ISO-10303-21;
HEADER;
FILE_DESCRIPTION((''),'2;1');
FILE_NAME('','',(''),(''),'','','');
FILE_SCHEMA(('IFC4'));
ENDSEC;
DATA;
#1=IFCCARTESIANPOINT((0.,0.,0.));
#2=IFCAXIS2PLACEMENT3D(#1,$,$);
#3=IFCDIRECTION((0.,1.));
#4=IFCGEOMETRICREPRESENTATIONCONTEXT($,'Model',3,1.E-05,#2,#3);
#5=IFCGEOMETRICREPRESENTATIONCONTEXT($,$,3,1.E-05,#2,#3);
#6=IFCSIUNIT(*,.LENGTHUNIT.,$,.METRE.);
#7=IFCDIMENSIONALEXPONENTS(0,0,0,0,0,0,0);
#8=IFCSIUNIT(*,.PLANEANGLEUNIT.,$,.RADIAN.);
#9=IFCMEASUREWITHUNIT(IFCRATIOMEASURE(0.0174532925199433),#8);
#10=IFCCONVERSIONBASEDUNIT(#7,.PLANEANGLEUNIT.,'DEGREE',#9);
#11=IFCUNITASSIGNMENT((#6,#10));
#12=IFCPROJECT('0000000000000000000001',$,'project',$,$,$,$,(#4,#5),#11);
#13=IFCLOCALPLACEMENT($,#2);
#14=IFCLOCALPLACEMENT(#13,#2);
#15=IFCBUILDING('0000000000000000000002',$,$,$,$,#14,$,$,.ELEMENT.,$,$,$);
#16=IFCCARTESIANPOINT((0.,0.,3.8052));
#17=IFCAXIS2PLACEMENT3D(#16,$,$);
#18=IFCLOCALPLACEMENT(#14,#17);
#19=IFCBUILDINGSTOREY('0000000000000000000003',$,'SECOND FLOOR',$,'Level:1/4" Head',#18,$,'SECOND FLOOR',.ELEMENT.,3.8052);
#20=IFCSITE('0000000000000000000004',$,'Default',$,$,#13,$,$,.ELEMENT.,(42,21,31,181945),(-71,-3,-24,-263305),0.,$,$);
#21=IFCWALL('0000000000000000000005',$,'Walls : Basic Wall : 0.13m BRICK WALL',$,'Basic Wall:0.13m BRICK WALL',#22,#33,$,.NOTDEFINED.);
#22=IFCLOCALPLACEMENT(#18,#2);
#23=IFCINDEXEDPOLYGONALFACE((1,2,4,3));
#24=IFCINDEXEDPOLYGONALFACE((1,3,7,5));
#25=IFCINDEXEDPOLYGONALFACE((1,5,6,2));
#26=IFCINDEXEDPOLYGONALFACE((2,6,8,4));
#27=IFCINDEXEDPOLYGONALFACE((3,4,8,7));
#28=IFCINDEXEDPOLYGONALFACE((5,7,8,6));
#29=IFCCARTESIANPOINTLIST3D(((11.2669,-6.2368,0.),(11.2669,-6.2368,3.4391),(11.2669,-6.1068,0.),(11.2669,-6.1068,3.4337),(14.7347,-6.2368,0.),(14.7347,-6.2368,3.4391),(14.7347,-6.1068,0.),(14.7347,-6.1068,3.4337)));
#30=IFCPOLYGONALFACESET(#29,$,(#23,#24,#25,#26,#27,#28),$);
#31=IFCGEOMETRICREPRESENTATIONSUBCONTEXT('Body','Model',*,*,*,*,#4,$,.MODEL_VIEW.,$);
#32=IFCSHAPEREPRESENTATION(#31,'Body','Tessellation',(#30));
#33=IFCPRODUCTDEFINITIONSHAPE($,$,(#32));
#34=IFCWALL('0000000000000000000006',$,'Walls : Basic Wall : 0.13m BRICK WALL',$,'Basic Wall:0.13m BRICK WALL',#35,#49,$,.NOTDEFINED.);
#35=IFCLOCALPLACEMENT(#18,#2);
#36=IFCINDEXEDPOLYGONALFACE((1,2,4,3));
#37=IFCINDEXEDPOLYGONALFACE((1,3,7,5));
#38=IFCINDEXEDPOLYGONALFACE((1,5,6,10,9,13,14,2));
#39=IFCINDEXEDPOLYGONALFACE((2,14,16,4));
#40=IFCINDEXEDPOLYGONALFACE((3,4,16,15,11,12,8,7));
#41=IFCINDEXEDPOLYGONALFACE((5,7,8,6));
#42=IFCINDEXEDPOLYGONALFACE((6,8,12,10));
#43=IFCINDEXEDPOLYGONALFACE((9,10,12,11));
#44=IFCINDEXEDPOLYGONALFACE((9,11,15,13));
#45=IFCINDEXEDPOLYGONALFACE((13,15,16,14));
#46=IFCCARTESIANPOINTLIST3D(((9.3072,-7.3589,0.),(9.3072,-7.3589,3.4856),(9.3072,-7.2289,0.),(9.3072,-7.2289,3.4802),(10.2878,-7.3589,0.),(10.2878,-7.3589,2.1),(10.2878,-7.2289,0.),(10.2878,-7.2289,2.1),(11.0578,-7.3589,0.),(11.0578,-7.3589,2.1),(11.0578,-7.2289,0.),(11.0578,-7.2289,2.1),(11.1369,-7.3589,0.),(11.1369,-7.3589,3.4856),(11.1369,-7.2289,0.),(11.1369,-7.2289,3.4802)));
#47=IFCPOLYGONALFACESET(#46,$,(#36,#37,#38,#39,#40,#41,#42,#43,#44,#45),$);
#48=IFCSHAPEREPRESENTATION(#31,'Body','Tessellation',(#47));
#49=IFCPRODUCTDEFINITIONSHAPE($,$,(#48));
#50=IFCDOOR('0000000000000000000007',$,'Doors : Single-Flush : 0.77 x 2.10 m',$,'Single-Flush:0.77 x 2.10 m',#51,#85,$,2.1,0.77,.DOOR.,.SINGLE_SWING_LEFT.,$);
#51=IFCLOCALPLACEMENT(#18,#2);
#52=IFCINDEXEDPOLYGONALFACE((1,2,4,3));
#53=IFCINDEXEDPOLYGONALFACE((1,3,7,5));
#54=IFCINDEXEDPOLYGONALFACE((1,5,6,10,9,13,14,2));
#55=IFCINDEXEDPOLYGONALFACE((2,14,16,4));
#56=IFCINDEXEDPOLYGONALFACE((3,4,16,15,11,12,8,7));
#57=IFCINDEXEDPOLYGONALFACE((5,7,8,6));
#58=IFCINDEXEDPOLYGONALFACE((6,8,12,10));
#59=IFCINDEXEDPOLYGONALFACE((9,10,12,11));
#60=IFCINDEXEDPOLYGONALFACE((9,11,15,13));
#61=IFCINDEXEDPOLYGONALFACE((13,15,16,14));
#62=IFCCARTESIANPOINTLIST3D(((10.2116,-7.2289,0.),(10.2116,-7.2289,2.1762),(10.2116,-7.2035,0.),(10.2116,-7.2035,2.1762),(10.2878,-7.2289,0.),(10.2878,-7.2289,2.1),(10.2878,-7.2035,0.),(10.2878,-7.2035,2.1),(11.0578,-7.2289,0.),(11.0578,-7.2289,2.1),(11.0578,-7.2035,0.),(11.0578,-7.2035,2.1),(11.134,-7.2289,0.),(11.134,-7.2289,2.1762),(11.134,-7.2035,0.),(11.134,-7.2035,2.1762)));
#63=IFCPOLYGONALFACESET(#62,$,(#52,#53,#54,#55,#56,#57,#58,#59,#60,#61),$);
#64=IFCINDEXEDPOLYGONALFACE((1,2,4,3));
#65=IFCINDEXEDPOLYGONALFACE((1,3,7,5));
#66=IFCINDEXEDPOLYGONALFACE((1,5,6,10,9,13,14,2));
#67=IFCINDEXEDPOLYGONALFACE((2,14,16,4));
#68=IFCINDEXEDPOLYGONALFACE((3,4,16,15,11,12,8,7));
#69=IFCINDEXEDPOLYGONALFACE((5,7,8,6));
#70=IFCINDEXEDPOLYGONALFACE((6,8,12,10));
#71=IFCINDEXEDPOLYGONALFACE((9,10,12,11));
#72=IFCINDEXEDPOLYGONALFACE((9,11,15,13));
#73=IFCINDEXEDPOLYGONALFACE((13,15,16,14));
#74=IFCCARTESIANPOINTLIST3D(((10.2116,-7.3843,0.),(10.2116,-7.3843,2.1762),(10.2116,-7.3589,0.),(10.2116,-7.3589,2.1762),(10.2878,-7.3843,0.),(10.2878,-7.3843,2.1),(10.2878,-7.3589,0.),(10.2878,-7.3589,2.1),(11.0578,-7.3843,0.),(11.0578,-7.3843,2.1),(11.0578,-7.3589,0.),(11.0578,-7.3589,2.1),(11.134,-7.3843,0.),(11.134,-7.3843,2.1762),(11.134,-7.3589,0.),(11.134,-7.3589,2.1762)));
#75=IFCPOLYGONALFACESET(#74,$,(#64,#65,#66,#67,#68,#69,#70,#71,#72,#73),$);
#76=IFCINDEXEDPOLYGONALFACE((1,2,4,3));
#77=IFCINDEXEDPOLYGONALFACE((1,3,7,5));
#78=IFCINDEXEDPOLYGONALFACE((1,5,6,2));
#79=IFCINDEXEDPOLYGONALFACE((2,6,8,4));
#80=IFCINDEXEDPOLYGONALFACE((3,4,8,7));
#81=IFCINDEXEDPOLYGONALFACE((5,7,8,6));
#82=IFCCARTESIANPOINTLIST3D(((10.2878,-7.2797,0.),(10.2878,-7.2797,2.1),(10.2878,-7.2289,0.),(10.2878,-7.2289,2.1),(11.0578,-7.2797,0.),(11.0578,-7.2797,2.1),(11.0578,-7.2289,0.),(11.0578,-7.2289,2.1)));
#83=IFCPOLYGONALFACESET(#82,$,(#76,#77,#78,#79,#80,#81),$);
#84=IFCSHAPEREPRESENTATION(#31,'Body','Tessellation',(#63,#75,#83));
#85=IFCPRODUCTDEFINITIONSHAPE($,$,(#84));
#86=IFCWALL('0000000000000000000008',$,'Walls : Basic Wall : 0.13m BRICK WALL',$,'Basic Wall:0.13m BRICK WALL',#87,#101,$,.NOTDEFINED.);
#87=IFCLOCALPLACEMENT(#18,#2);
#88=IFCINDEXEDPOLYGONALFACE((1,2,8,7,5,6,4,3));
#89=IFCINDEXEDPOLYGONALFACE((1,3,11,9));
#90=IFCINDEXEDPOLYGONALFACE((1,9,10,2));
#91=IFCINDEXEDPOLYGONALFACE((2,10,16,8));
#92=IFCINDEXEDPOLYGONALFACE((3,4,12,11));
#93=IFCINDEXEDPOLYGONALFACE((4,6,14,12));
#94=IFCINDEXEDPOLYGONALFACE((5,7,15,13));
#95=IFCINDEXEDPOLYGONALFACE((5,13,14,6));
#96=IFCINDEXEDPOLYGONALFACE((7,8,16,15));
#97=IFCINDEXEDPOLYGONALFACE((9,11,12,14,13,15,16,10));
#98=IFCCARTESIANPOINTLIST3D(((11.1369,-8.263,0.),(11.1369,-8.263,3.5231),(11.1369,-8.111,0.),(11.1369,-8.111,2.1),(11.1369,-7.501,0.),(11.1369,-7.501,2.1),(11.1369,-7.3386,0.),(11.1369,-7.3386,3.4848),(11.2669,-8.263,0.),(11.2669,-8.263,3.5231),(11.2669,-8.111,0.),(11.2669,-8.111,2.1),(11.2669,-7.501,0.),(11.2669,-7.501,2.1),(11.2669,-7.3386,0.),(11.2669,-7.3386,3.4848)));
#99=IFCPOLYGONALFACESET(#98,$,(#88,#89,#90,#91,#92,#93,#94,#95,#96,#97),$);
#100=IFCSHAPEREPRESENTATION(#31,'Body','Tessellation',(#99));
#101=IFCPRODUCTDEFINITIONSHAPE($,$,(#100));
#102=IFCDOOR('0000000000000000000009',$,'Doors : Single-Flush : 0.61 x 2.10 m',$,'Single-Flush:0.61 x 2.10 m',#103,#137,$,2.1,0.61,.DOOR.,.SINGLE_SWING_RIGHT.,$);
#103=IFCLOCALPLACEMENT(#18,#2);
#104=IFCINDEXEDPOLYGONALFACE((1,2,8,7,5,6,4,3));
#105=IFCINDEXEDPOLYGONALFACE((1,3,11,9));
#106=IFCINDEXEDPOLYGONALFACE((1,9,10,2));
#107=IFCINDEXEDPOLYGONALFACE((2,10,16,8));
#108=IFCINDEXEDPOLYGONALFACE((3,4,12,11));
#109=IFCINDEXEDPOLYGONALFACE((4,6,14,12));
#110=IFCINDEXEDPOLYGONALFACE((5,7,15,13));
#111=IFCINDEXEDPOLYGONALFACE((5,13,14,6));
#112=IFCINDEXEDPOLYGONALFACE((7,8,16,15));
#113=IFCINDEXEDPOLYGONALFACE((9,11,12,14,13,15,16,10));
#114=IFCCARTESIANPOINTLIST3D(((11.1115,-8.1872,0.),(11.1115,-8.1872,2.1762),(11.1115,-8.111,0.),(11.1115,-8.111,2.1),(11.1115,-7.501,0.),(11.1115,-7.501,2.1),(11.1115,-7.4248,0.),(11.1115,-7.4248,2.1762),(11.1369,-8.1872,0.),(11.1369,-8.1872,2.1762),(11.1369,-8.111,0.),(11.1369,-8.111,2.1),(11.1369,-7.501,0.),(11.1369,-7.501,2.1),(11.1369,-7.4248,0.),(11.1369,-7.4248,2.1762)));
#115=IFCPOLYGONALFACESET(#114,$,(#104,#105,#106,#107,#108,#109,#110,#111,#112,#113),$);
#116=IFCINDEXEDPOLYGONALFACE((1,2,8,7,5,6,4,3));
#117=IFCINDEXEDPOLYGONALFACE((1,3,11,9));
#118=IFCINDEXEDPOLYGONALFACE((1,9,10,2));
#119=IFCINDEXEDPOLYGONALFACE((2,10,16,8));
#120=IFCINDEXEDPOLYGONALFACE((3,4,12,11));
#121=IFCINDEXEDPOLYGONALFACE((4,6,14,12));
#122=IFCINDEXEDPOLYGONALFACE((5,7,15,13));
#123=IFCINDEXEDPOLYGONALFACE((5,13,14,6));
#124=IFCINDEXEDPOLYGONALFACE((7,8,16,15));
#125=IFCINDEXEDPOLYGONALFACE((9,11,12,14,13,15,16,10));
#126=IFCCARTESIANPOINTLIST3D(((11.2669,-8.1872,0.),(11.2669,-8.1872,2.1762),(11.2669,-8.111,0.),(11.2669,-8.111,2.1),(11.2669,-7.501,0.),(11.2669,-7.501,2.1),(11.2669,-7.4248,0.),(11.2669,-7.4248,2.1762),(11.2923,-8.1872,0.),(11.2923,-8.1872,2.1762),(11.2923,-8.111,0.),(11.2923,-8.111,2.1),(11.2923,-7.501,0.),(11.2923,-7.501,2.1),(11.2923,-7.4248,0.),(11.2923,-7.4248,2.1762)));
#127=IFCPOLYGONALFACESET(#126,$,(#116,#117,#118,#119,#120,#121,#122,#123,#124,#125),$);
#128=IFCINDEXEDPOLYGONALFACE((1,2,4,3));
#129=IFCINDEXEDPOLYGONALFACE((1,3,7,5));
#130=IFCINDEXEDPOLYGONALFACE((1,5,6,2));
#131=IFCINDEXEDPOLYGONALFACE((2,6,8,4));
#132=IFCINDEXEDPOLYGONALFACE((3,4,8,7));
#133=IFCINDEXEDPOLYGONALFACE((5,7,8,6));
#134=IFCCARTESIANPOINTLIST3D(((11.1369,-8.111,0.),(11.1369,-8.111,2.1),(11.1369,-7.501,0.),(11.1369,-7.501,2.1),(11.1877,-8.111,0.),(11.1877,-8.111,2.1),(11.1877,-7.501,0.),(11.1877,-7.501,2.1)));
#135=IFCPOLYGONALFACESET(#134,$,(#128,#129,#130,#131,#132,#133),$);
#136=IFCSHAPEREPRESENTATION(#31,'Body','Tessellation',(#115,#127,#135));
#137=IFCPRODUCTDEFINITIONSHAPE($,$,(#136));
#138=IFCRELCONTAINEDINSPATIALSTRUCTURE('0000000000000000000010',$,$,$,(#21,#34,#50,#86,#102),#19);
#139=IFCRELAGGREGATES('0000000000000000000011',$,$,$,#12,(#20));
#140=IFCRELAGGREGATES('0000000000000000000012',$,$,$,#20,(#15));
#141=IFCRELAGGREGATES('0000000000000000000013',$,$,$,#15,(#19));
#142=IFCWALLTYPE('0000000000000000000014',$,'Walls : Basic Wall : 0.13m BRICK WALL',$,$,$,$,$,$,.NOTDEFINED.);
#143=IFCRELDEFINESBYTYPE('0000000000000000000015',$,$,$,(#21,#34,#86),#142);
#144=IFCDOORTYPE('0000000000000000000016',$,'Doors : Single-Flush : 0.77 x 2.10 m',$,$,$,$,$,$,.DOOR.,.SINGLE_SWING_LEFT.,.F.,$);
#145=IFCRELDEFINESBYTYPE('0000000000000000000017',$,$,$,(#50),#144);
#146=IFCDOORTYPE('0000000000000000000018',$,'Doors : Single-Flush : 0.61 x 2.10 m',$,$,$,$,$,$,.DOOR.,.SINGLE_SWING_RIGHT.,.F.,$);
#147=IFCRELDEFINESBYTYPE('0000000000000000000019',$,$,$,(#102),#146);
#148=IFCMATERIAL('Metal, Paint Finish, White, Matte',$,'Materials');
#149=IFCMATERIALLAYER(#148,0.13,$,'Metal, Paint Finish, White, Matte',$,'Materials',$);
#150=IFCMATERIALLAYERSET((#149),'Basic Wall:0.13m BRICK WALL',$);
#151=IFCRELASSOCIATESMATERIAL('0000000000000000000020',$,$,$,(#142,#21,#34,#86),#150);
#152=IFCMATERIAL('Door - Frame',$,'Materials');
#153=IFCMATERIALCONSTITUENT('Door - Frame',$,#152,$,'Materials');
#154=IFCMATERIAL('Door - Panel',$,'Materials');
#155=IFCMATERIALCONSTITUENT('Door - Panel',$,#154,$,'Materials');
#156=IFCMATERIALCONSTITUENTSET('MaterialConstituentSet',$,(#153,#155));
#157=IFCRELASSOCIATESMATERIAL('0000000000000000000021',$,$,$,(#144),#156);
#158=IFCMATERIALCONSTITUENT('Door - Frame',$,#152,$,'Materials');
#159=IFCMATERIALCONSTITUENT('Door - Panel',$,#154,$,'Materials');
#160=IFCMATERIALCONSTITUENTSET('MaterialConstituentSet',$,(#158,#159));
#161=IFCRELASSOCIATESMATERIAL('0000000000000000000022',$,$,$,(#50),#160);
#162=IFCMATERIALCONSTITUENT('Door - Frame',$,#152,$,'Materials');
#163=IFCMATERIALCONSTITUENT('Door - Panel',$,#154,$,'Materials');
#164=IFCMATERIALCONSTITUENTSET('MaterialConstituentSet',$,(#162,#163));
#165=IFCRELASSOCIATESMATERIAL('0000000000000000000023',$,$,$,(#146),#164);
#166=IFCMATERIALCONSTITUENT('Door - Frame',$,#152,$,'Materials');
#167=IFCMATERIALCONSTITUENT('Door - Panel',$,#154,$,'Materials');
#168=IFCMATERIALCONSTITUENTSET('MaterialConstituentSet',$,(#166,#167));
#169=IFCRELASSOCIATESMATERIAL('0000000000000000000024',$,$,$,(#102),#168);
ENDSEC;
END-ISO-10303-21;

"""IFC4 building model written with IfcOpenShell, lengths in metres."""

from ifc_helpers import new_model, entity, si_unit, converted_unit, direction, frame, frame_2d, origin, place, context, subcontext, project, spatial, polyline, rectangle, outline, extrude, clip, bounded_halfspace, source, transform, mapped, material, layer, layer_set, layer_usage, constituent, constituent_set, type_object, type_shapes, element, fill, save


model = new_model("IFC4")

# Units and contexts
model_context = context("Model", 3, precision=1e-05, world=origin(), true_north=direction((0.0, 1.0)))
context_of_model = context(None, 3, precision=1e-05, world=origin(), true_north=direction((0.0, 1.0)))
body_context = subcontext(model_context, "Body", "Model", "MODEL_VIEW")
ifc_project = project(units=[si_unit("LENGTHUNIT", "METRE"), converted_unit("PLANEANGLEUNIT", "DEGREE", entity("IfcRatioMeasure", 0.0174532925199433), si_unit("PLANEANGLEUNIT", "RADIAN"), dimensions=[0, 0, 0, 0, 0, 0, 0])], contexts=[model_context, context_of_model])

# Site, building, storey
site_placement = place(None, origin())
site = spatial("IfcSite", under=ifc_project, at=site_placement, Name="Default", CompositionType="ELEMENT", RefLatitude=(42, 21, 31, 181945), RefLongitude=(-71, -3, -24, -263305), RefElevation=0.0)
building_placement = place(site_placement, origin())
building = spatial("IfcBuilding", under=site, at=building_placement, CompositionType="ELEMENT")
storey_placement = place(building_placement, frame((0.0, 0.0, 3.8052)))
storey = spatial("IfcBuildingStorey", under=building, at=storey_placement, Name="SECOND FLOOR", ObjectType="Level:1/4\" Head", LongName="SECOND FLOOR", CompositionType="ELEMENT", Elevation=3.8052)

# Wall
ifc_material_1 = material(Name="Metal, Paint Finish, White, Matte", Category="Materials")
ifc_layer_1 = layer(ifc_material_1, 0.13, Name="Metal, Paint Finish, White, Matte", Category="Materials")
ifc_layer_set_1 = layer_set([ifc_layer_1], Name="Basic Wall:0.13m BRICK WALL")
ifc_layer_usage_1 = layer_usage(ifc_layer_set_1, "AXIS2", "NEGATIVE", 0.065)
wall_type_1 = type_object("IfcWallType", Name="Walls : Basic Wall : 0.13m BRICK WALL", PredefinedType="NOTDEFINED", material=ifc_layer_set_1)
wall_1_placement = place(storey_placement, frame((14.7347, -6.1718, 0.0), z_axis=(0.0, 0.0, 1.0), x_axis=(-1.0, 0.0, 0.0)))
element("IfcWall", 1, at=wall_1_placement, inside=storey, type_object=wall_type_1, material=ifc_layer_usage_1, Name="Walls : Basic Wall : 0.13m BRICK WALL", ObjectType="Basic Wall:0.13m BRICK WALL", PredefinedType="NOTDEFINED", context=body_context, shape_type="Clipping", body=[
    clip(extrude(rectangle(XDim=3.4678, YDim=0.13, at=frame_2d((1.7339, 0.0), x_axis=(-1.0, 0.0))), origin(), (0.0, 0.0, 1.0), 3.4391), bounded_halfspace(frame((0.0, -0.065, 3.4337), z_axis=(0.0, 0.041435, -0.999141), x_axis=(1.0, 0.0, 0.0)), True, frame((0.0, -0.065, 3.4337)), polyline([(0.0, 0.0), (2.4453, 0.0), (2.5453, 0.0), (3.4678, 0.0), (3.4678, 0.13), (0.0, 0.13), (0.0, 0.0)]))),
])

# Walls, openings, doors
ifc_layer_usage_2 = layer_usage(ifc_layer_set_1, "AXIS2", "NEGATIVE", 0.065)
wall_2_placement = place(storey_placement, frame((11.1369, -7.2939, 0.0), z_axis=(0.0, 0.0, 1.0), x_axis=(-1.0, 0.0, 0.0)))
wall_2 = element("IfcWall", 2, at=wall_2_placement, inside=storey, type_object=wall_type_1, material=ifc_layer_usage_2, Name="Walls : Basic Wall : 0.13m BRICK WALL", ObjectType="Basic Wall:0.13m BRICK WALL", PredefinedType="NOTDEFINED", context=body_context, shape_type="Clipping", body=[
    clip(extrude(rectangle(XDim=1.8297, YDim=0.13, at=frame_2d((0.9149, 0.0), x_axis=(-1.0, 0.0))), origin(), (0.0, 0.0, 1.0), 3.4856), bounded_halfspace(frame((0.0, -0.065, 3.4802), z_axis=(0.0, 0.041435, -0.999141), x_axis=(1.0, 0.0, 0.0)), True, frame((0.0, -0.065, 3.4802)), polyline([(0.0, 0.0), (1.8297, 0.0), (1.8297, 0.13), (0.0, 0.13), (0.0, 0.02), (0.0, 0.0)]))),
])
opening_1_placement = place(wall_2_placement, frame((0.8491, 0.065, 0.0)))
opening_1 = element("IfcOpeningElement", 3, at=opening_1_placement, cuts=wall_2, ObjectType="Opening", PredefinedType="OPENING", context=body_context, shape_type="SweptSolid", body=[
    extrude(rectangle(XDim=0.77, YDim=2.1, at=frame_2d((1.05, 0.385), x_axis=(0.0, -1.0))), frame((0.0, 0.0, 0.0), z_axis=(0.0, -1.0, 0.0), x_axis=(0.0, 0.0, 1.0)), (0.0, 0.0, 1.0), 0.13),
])
ifc_material_2 = material(Name="Door - Frame", Category="Materials")
ifc_constituent_1 = constituent(ifc_material_2, Name="Door - Frame", Category="Materials")
ifc_material_3 = material(Name="Door - Panel", Category="Materials")
ifc_constituent_2 = constituent(ifc_material_3, Name="Door - Panel", Category="Materials")
ifc_constituent_set_1 = constituent_set(constituents=[ifc_constituent_1, ifc_constituent_2], Name="MaterialConstituentSet")
ifc_constituent_3 = constituent(ifc_material_2, Name="Door - Frame", Category="Materials")
ifc_constituent_4 = constituent(ifc_material_3, Name="Door - Panel", Category="Materials")
ifc_constituent_set_2 = constituent_set(constituents=[ifc_constituent_3, ifc_constituent_4], Name="MaterialConstituentSet")
door_type_1 = type_object("IfcDoorType", Name="Doors : Single-Flush : 0.77 x 2.10 m", OperationType="SINGLE_SWING_LEFT", ParameterTakesPrecedence=False, PredefinedType="DOOR", material=ifc_constituent_set_2)
shared_shape_1 = source(origin(), body_context, "Body", "SweptSolid", [
    extrude(outline(polyline([(-0.4612, -1.1072), (0.4612, -1.1072), (0.4612, 1.0691), (0.385, 1.0691), (0.385, -1.031), (-0.385, -1.031), (-0.385, 1.0691), (-0.4612, 1.0691), (-0.4612, -1.1072)])), frame((0.385, 0.1554, 1.0691), z_axis=(0.0, -1.0, 0.0), x_axis=(-1.0, 0.0, 0.0)), (0.0, 0.0, 1.0), 0.0254),
    extrude(outline(polyline([(-1.1072, -0.4612), (1.0691, -0.4612), (1.0691, -0.385), (-1.031, -0.385), (-1.031, 0.385), (1.0691, 0.385), (1.0691, 0.4612), (-1.1072, 0.4612), (-1.1072, -0.4612)])), frame((0.385, 0.0, 1.0691), z_axis=(0.0, -1.0, 0.0), x_axis=(0.0, 0.0, -1.0)), (0.0, 0.0, 1.0), 0.0254),
    extrude(rectangle(XDim=0.77, YDim=0.0508, at=frame_2d((0.0, 0.0), x_axis=(1.0, 0.0))), frame((0.385, 0.1046, 0.0)), (0.0, 0.0, 1.0), 2.1),
])
type_shapes(door_type_1, [shared_shape_1])
door_1_placement = place(opening_1_placement, frame((0.0, 0.0, 0.0), z_axis=(0.0, 0.0, 1.0), x_axis=(-1.0, 0.0, 0.0)))
door_1 = element("IfcDoor", 4, at=door_1_placement, inside=storey, type_object=door_type_1, material=ifc_constituent_set_1, Name="Doors : Single-Flush : 0.77 x 2.10 m", ObjectType="Single-Flush:0.77 x 2.10 m", OperationType="SINGLE_SWING_LEFT", OverallHeight=2.1, OverallWidth=0.77, PredefinedType="DOOR", context=body_context, shape_type="MappedRepresentation", body=[
    mapped(shared_shape_1, transform((0.0, 0.0, 0.0), scale=1.0)),
])
fill(opening_1, door_1)
ifc_layer_usage_3 = layer_usage(ifc_layer_set_1, "AXIS2", "NEGATIVE", 0.065)
wall_3_placement = place(storey_placement, frame((11.2019, -8.263, 0.0), z_axis=(0.0, 0.0, 1.0), x_axis=(0.0, 1.0, 0.0)))
wall_3 = element("IfcWall", 5, at=wall_3_placement, inside=storey, type_object=wall_type_1, material=ifc_layer_usage_3, Name="Walls : Basic Wall : 0.13m BRICK WALL", ObjectType="Basic Wall:0.13m BRICK WALL", PredefinedType="NOTDEFINED", context=body_context, shape_type="Clipping", body=[
    clip(extrude(rectangle(XDim=0.9244, YDim=0.13, at=frame_2d((0.4622, 0.0), x_axis=(-1.0, 0.0))), origin(), (0.0, 0.0, 1.0), 3.5231), bounded_halfspace(frame((0.0, -0.065, 3.5231), z_axis=(-0.041435, 0.0, -0.999141), x_axis=(0.0, 1.0, 0.0)), True, frame((0.0, -0.065, 3.5231)), polyline([(0.0, 0.0), (0.9244, 0.0), (0.9244, 0.13), (0.0, 0.13), (0.0, 0.0)]))),
])
opening_2_placement = place(wall_3_placement, frame((0.1521, -0.065, 0.0)))
opening_2 = element("IfcOpeningElement", 6, at=opening_2_placement, cuts=wall_3, ObjectType="Opening", PredefinedType="OPENING", context=body_context, shape_type="SweptSolid", body=[
    extrude(rectangle(XDim=0.61, YDim=2.1, at=frame_2d((1.05, 0.305), x_axis=(0.0, 1.0))), frame((0.0, 0.0, 0.0), z_axis=(0.0, 1.0, 0.0), x_axis=(0.0, 0.0, 1.0)), (0.0, 0.0, 1.0), 0.13),
])
ifc_constituent_5 = constituent(ifc_material_2, Name="Door - Frame", Category="Materials")
ifc_constituent_6 = constituent(ifc_material_3, Name="Door - Panel", Category="Materials")
ifc_constituent_set_3 = constituent_set(constituents=[ifc_constituent_5, ifc_constituent_6], Name="MaterialConstituentSet")
ifc_constituent_7 = constituent(ifc_material_2, Name="Door - Frame", Category="Materials")
ifc_constituent_8 = constituent(ifc_material_3, Name="Door - Panel", Category="Materials")
ifc_constituent_set_4 = constituent_set(constituents=[ifc_constituent_7, ifc_constituent_8], Name="MaterialConstituentSet")
door_type_2 = type_object("IfcDoorType", Name="Doors : Single-Flush : 0.61 x 2.10 m", OperationType="SINGLE_SWING_RIGHT", ParameterTakesPrecedence=False, PredefinedType="DOOR", material=ifc_constituent_set_4)
shared_shape_2 = source(origin(), body_context, "Body", "SweptSolid", [
    extrude(outline(polyline([(-0.3812, -1.1072), (0.3812, -1.1072), (0.3812, 1.0691), (0.305, 1.0691), (0.305, -1.031), (-0.305, -1.031), (-0.305, 1.0691), (-0.3812, 1.0691), (-0.3812, -1.1072)])), frame((0.305, 0.13, 1.0691), z_axis=(0.0, 1.0, 0.0), x_axis=(1.0, 0.0, 0.0)), (0.0, 0.0, 1.0), 0.0254),
    extrude(outline(polyline([(-1.1072, -0.3812), (1.0691, -0.3812), (1.0691, -0.305), (-1.031, -0.305), (-1.031, 0.305), (1.0691, 0.305), (1.0691, 0.3812), (-1.1072, 0.3812), (-1.1072, -0.3812)])), frame((0.305, -0.0254, 1.0691), z_axis=(0.0, 1.0, 0.0), x_axis=(0.0, 0.0, -1.0)), (0.0, 0.0, 1.0), 0.0254),
    extrude(rectangle(XDim=0.0508, YDim=0.61, at=frame_2d((0.0, 0.0), x_axis=(1.0, 0.0))), frame((0.305, 0.1046, 0.0), z_axis=(0.0, 0.0, 1.0), x_axis=(0.0, 1.0, 0.0)), (0.0, 0.0, 1.0), 2.1),
])
type_shapes(door_type_2, [shared_shape_2])
door_2_placement = place(opening_2_placement, origin())
door_2 = element("IfcDoor", 7, at=door_2_placement, inside=storey, type_object=door_type_2, material=ifc_constituent_set_3, Name="Doors : Single-Flush : 0.61 x 2.10 m", ObjectType="Single-Flush:0.61 x 2.10 m", OperationType="SINGLE_SWING_RIGHT", OverallHeight=2.1, OverallWidth=0.61, PredefinedType="DOOR", context=body_context, shape_type="MappedRepresentation", body=[
    mapped(shared_shape_2, transform((0.0, 0.0, 0.0), scale=1.0)),
])
fill(opening_2, door_2)

save(model, "model.ifc")
